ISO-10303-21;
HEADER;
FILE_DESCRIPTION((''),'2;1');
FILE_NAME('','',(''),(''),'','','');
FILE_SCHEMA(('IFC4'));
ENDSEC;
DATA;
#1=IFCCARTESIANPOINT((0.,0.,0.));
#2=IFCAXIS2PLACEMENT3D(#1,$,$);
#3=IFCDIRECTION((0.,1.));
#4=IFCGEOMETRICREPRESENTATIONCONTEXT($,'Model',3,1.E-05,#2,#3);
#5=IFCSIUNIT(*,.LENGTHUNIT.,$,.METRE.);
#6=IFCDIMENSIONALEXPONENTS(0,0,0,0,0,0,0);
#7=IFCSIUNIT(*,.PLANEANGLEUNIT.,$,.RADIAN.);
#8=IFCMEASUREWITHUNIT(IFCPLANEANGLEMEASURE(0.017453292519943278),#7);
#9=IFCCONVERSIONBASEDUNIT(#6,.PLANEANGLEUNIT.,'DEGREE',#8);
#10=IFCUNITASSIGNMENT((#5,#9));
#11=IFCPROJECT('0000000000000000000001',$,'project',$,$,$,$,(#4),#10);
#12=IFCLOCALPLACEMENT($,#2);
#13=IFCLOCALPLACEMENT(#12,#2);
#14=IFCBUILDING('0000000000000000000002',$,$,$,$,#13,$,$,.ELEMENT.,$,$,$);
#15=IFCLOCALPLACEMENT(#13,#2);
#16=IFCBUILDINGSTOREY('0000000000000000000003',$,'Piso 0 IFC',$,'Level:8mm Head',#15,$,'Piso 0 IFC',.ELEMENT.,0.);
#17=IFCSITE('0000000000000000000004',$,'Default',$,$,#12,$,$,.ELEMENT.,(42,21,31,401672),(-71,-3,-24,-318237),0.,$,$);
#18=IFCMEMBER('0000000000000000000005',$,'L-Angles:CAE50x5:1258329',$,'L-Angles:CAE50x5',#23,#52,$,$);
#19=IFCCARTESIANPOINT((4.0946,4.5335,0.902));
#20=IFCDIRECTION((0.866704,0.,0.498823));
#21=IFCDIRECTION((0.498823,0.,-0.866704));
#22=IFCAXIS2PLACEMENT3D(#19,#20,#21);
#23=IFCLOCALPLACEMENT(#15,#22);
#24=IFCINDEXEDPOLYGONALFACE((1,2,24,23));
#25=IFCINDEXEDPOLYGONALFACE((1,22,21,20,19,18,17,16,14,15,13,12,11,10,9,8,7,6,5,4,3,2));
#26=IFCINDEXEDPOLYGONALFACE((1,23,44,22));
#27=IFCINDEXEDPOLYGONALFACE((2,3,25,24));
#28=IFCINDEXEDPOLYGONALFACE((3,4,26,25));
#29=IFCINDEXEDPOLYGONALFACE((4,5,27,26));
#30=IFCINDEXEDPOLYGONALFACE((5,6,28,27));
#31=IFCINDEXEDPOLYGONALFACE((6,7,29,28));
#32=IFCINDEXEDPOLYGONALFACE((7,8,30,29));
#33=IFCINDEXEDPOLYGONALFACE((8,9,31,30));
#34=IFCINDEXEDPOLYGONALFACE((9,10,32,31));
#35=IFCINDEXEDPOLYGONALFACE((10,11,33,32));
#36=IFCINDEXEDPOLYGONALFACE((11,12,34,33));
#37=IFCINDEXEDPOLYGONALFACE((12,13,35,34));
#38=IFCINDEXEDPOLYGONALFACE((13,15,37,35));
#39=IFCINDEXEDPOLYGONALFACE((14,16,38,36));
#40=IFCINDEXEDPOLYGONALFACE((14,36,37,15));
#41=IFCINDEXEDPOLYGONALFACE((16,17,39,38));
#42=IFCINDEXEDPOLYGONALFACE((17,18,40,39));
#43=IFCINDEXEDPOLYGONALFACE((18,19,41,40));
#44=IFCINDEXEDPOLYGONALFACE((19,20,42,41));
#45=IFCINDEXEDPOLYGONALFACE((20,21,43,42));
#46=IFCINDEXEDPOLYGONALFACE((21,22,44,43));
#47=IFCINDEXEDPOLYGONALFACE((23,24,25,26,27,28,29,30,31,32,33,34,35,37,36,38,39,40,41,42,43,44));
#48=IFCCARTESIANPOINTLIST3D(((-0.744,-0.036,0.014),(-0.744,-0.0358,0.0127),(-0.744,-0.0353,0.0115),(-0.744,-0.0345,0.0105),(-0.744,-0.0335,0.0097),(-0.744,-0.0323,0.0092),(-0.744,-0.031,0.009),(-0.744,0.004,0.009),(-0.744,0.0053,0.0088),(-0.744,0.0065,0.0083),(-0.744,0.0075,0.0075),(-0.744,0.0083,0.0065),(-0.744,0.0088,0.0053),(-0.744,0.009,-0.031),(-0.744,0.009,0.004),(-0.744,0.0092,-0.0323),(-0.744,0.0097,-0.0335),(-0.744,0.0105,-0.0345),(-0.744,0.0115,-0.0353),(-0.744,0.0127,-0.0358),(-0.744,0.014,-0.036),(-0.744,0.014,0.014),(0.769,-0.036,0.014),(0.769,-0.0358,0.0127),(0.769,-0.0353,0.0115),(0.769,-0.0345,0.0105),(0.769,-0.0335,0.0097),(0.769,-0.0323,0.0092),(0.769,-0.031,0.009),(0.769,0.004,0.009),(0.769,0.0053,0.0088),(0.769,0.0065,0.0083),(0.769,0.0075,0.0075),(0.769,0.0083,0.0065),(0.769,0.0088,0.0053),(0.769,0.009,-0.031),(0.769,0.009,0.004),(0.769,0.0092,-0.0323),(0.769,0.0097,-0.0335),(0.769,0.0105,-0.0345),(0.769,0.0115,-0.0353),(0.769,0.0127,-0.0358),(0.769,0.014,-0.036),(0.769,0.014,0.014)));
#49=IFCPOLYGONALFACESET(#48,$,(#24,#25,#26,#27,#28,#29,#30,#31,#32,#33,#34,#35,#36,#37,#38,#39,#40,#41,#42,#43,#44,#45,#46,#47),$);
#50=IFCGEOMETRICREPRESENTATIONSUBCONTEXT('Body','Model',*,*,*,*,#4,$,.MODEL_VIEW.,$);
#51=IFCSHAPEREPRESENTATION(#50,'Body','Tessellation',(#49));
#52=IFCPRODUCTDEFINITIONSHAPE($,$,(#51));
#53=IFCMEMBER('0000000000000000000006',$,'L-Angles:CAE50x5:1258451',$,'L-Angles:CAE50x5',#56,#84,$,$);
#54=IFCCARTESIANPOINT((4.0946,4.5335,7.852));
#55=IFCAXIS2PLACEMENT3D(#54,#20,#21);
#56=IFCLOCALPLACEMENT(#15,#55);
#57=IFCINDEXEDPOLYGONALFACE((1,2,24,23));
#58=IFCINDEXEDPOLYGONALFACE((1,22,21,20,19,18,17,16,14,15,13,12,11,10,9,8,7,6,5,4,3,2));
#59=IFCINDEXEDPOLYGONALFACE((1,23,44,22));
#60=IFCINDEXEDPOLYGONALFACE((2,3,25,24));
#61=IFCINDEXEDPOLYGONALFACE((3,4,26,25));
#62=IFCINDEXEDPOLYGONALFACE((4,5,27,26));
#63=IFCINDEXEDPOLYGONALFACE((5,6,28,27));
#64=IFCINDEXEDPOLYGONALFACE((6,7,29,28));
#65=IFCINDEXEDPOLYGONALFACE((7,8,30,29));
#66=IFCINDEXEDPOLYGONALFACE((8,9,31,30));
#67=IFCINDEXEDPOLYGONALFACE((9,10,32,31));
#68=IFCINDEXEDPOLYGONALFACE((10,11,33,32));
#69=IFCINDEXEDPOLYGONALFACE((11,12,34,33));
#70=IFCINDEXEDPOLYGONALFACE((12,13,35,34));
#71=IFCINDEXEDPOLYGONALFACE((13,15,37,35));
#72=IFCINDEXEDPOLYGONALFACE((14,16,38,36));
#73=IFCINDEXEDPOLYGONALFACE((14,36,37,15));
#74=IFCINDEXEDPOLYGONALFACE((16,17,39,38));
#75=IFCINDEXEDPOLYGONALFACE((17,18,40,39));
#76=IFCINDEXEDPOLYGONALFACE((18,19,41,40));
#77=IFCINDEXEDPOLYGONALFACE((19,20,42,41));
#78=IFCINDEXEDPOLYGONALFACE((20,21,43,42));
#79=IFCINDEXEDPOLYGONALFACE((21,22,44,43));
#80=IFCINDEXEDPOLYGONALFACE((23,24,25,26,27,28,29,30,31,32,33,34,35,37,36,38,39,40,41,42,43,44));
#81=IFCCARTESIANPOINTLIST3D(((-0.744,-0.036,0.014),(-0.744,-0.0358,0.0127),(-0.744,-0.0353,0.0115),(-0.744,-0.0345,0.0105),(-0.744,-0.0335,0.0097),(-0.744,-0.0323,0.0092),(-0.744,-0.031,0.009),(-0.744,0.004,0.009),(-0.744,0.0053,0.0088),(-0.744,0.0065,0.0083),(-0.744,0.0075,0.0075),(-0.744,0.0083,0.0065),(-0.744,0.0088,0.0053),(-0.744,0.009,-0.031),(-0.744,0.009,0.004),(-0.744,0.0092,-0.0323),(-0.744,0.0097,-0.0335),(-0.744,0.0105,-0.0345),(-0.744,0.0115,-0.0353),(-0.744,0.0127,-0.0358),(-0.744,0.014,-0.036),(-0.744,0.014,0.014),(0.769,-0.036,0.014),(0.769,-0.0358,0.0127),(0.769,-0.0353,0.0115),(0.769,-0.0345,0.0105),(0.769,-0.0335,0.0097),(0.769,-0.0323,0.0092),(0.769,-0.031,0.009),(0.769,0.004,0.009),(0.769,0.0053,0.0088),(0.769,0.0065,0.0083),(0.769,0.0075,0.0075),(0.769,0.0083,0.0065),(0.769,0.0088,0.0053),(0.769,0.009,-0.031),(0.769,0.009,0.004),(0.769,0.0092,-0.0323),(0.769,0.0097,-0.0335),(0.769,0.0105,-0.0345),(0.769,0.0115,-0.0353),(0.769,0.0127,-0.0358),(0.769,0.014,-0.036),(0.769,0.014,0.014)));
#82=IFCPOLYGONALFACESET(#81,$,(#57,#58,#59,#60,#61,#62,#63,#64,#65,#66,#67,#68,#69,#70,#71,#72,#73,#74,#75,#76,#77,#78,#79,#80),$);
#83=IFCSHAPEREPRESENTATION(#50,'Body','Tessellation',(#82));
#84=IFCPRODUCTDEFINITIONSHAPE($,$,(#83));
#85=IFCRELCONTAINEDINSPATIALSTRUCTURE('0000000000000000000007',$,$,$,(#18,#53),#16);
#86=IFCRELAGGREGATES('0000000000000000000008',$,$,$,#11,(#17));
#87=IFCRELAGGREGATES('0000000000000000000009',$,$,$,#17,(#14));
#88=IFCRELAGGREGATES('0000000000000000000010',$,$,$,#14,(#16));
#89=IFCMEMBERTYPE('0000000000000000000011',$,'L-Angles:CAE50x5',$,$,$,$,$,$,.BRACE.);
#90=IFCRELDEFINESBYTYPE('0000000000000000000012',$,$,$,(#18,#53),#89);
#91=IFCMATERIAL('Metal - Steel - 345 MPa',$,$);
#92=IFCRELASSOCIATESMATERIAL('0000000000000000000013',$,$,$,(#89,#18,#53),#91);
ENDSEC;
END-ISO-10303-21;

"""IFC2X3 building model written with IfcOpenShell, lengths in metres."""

from ifc_helpers import new_model, entity, si_unit, converted_unit, direction, frame, frame_2d, origin, place, context, subcontext, project, spatial, polyline, circle_curve, parameter, trimmed, segment, composite_curve, outline, extrude, source, transform, mapped, material, type_object, type_shapes, element, save


model = new_model("IFC2X3")

# Units and contexts
model_context = context("Model", 3, precision=1e-05, world=origin(), true_north=direction((0.0, 1.0)))
body_context = subcontext(model_context, "Body", "Model", "MODEL_VIEW")
ifc_project = project(units=[si_unit("LENGTHUNIT", "METRE"), converted_unit("PLANEANGLEUNIT", "DEGREE", entity("IfcPlaneAngleMeasure", 0.017453292519943278), si_unit("PLANEANGLEUNIT", "RADIAN"), dimensions=[0, 0, 0, 0, 0, 0, 0])], contexts=[model_context])

# Site, building, storey
site_placement = place(None, origin())
site = spatial("IfcSite", under=ifc_project, at=site_placement, Name="Default", CompositionType="ELEMENT", RefLatitude=(42, 21, 31, 401672), RefLongitude=(-71, -3, -24, -318237), RefElevation=0.0)
building_placement = place(site_placement, origin())
building = spatial("IfcBuilding", under=site, at=building_placement, CompositionType="ELEMENT")
storey_placement = place(building_placement, origin())
storey = spatial("IfcBuildingStorey", under=building, at=storey_placement, Name="Piso 0 IFC", ObjectType="Level:8mm Head", LongName="Piso 0 IFC", CompositionType="ELEMENT", Elevation=0.0)

# Shared definitions
ifc_material_1 = material(Name="Metal - Steel - 345 MPa")

# Members
member_type_1 = type_object("IfcMemberType", Name="L-Angles:CAE50x5", PredefinedType="BRACE", material=ifc_material_1)
shared_shape_1 = source(origin(), body_context, "Body", "SweptSolid", [
    extrude(outline(composite_curve([segment(polyline([(-0.0164, -0.0164), (0.0336, -0.0164)]), True, "CONTINUOUS"), segment(trimmed(circle_curve(frame_2d((0.0286, -0.0164), x_axis=(1.0, 0.0)), 0.005), [parameter(0.0)], [parameter(90.0)], True, "PARAMETER"), True, "CONTINUOUS"), segment(polyline([(0.0286, -0.0114), (-0.0064, -0.0114)]), True, "CONTINUOUS"), segment(trimmed(circle_curve(frame_2d((-0.0064, -0.0064), x_axis=(1.0, 0.0)), 0.005), [parameter(180.0)], [parameter(270.0)], True, "PARAMETER"), False, "CONTINUOUS"), segment(polyline([(-0.0114, -0.0064), (-0.0114, 0.0286)]), True, "CONTINUOUS"), segment(trimmed(circle_curve(frame_2d((-0.0164, 0.0286), x_axis=(1.0, 0.0)), 0.005), [parameter(0.0)], [parameter(90.0)], True, "PARAMETER"), True, "CONTINUOUS"), segment(polyline([(-0.0164, 0.0336), (-0.0164, -0.0164)]), True, "CONTINUOUS")], self_intersect=False)), frame((-0.744, -0.0024, -0.0024), z_axis=(1.0, 0.0, 0.0), x_axis=(0.0, -1.0, 0.0)), (0.0, 0.0, 1.0), 1.513),
])
type_shapes(member_type_1, [shared_shape_1])
for number, where, z_axis, x_axis, name in (
    (1, (4.0946, 4.5335, 0.902), (0.866704, 0.0, 0.498823), (0.498823, 0.0, -0.866704), "L-Angles:CAE50x5:1258329"),
    (2, (4.0946, 4.5335, 7.852), (0.866704, 0.0, 0.498823), (0.498823, 0.0, -0.866704), "L-Angles:CAE50x5:1258451"),
):
    element("IfcMember", number, at=place(storey_placement, frame(where, z_axis=z_axis, x_axis=x_axis)), inside=storey, type_object=member_type_1, material=ifc_material_1, Name=name, ObjectType="L-Angles:CAE50x5", context=body_context, shape_type="MappedRepresentation", body=[
        mapped(shared_shape_1, transform((0.0, 0.0, 0.0), scale=1.0)),
    ])

save(model, "model.ifc")
